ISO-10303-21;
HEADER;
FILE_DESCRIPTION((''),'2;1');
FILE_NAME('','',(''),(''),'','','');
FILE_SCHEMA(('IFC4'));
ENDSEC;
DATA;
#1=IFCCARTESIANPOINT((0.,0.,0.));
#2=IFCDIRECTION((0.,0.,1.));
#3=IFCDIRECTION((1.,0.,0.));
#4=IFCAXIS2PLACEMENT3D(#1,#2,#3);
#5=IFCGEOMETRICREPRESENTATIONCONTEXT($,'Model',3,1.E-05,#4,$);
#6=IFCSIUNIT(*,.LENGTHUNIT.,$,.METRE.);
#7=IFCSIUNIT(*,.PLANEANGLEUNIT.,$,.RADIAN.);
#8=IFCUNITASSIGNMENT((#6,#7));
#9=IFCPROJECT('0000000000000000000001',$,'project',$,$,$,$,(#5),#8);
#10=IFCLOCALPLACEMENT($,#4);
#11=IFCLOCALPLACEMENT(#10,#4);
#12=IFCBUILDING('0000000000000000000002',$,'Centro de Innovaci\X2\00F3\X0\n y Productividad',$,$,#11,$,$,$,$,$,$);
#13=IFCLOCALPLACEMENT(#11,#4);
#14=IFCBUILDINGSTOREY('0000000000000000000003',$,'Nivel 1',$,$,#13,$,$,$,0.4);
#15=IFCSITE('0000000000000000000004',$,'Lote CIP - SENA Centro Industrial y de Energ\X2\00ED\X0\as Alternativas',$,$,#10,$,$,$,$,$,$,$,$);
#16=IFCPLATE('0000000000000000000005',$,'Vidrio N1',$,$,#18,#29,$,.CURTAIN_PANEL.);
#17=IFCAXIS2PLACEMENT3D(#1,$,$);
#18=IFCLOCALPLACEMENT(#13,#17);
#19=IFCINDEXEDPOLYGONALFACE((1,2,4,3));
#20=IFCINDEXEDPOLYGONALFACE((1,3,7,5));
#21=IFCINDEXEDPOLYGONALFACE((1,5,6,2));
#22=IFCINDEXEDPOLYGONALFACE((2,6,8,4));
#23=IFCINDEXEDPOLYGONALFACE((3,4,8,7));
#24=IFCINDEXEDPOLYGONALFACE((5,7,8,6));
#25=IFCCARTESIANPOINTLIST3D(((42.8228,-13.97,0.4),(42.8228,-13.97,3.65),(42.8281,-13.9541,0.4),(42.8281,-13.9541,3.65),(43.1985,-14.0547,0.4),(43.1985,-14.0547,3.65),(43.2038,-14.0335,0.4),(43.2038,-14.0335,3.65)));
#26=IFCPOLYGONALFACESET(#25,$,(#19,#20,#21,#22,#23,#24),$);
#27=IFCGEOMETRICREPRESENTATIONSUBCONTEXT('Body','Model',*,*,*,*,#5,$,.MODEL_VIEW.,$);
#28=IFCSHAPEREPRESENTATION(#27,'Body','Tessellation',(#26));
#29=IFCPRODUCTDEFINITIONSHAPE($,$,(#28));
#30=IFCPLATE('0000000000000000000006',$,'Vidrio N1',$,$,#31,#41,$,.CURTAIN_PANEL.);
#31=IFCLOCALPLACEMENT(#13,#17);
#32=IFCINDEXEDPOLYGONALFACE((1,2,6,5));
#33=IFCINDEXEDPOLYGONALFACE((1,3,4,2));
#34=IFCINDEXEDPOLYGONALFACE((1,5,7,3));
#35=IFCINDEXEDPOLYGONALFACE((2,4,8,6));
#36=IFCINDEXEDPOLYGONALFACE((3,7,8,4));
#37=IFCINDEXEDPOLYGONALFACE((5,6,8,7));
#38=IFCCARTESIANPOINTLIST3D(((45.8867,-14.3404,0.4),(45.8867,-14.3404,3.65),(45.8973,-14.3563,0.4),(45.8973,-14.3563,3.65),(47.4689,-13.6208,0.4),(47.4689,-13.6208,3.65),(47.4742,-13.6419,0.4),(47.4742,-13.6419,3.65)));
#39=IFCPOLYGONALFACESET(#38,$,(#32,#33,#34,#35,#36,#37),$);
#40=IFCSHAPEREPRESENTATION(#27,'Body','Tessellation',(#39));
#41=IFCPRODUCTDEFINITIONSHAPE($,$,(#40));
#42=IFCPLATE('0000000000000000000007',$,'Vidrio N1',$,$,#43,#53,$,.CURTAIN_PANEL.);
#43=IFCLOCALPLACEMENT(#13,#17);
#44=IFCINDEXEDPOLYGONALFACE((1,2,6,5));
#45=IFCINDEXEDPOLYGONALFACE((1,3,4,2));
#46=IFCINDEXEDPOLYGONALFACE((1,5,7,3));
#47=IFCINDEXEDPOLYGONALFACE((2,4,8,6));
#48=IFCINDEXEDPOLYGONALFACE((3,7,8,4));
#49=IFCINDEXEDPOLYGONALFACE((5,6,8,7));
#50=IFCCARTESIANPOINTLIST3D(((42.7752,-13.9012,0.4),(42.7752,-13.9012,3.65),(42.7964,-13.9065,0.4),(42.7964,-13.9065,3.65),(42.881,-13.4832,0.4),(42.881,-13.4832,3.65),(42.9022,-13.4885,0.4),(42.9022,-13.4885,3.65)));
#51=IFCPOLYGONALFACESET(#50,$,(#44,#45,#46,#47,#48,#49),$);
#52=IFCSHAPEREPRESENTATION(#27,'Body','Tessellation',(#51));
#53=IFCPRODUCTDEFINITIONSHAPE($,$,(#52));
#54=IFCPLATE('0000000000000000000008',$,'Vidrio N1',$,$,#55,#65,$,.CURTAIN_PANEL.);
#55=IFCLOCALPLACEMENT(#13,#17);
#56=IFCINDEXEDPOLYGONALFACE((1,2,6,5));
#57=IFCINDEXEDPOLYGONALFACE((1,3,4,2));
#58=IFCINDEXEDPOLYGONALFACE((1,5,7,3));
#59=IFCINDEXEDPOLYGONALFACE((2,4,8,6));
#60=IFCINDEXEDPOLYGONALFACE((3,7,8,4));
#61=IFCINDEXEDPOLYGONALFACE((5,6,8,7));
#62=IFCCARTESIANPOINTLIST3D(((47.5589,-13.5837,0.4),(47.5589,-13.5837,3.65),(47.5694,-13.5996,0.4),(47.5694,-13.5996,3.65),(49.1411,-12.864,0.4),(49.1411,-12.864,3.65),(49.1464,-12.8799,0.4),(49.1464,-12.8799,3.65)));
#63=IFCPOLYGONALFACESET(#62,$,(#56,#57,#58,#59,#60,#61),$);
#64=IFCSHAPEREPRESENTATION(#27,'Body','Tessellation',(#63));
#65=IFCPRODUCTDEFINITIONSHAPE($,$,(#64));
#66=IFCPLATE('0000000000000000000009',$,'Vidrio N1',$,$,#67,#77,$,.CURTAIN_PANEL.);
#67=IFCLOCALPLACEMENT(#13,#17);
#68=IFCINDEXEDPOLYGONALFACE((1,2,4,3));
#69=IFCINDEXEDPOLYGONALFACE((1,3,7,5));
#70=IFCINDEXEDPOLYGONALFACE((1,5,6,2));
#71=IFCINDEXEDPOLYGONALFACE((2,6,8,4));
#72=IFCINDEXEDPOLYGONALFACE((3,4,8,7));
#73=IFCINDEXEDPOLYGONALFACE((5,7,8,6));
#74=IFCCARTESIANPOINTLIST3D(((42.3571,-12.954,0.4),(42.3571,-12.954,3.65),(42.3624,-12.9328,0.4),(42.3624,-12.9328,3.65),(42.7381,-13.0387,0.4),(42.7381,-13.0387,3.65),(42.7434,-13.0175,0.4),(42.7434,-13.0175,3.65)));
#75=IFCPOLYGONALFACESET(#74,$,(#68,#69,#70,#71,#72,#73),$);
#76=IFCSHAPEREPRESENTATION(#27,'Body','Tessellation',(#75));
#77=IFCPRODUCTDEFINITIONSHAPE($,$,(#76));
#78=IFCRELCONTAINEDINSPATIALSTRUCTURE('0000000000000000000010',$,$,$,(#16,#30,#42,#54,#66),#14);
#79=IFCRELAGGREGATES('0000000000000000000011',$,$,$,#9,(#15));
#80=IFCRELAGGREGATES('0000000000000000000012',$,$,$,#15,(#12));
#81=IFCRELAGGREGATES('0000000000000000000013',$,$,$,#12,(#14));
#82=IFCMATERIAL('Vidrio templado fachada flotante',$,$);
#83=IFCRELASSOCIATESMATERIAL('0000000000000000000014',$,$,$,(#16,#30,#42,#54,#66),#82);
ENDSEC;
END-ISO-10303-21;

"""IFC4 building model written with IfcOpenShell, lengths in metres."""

from ifc_helpers import new_model, si_unit, frame, origin_with_axes, place, context, subcontext, project, spatial, polyline, outline, extrude, material, element, save


model = new_model("IFC4")

# Units and contexts
model_context = context("Model", 3, precision=1e-05, world=origin_with_axes())
body_context = subcontext(model_context, "Body", "Model", "MODEL_VIEW")
ifc_project = project(units=[si_unit("LENGTHUNIT", "METRE"), si_unit("PLANEANGLEUNIT", "RADIAN")], contexts=[model_context])

# Site, building, storey
site_placement = place(None, origin_with_axes())
site = spatial("IfcSite", under=ifc_project, at=site_placement, Name="Lote CIP - SENA Centro Industrial y de Energías Alternativas")
building_placement = place(site_placement, origin_with_axes())
building = spatial("IfcBuilding", under=site, at=building_placement, Name="Centro de Innovación y Productividad")
storey_placement = place(building_placement, origin_with_axes())
storey = spatial("IfcBuildingStorey", under=building, at=storey_placement, Name="Nivel 1", Elevation=0.4)

# Plates
ifc_material = material(Name="Vidrio templado fachada flotante")
plate_1_placement = place(storey_placement, origin_with_axes())
element("IfcPlate", 1, at=plate_1_placement, inside=storey, material=ifc_material, Name="Vidrio N1", PredefinedType="CURTAIN_PANEL", context=body_context, shape_type="SweptSolid", body=[
    extrude(outline(polyline([(42.8228, -13.97), (42.8281, -13.9541), (43.2038, -14.0335), (43.1985, -14.0547), (42.8228, -13.97)])), frame((0.0, 0.0, 0.4)), (0.0, 0.0, 1.0), 3.25),
])
plate_2_placement = place(storey_placement, origin_with_axes())
element("IfcPlate", 2, at=plate_2_placement, inside=storey, material=ifc_material, Name="Vidrio N1", PredefinedType="CURTAIN_PANEL", context=body_context, shape_type="SweptSolid", body=[
    extrude(outline(polyline([(47.4742, -13.6419), (45.8973, -14.3563), (45.8867, -14.3404), (47.4689, -13.6208), (47.4742, -13.6419)])), frame((0.0, 0.0, 0.4)), (0.0, 0.0, 1.0), 3.25),
])
plate_3_placement = place(storey_placement, origin_with_axes())
element("IfcPlate", 3, at=plate_3_placement, inside=storey, material=ifc_material, Name="Vidrio N1", PredefinedType="CURTAIN_PANEL", context=body_context, shape_type="SweptSolid", body=[
    extrude(outline(polyline([(42.9022, -13.4885), (42.7964, -13.9065), (42.7752, -13.9012), (42.881, -13.4832), (42.9022, -13.4885)])), frame((0.0, 0.0, 0.4)), (0.0, 0.0, 1.0), 3.25),
])
plate_4_placement = place(storey_placement, origin_with_axes())
element("IfcPlate", 4, at=plate_4_placement, inside=storey, material=ifc_material, Name="Vidrio N1", PredefinedType="CURTAIN_PANEL", context=body_context, shape_type="SweptSolid", body=[
    extrude(outline(polyline([(47.5694, -13.5996), (47.5589, -13.5837), (49.1411, -12.864), (49.1464, -12.8799), (47.5694, -13.5996)])), frame((0.0, 0.0, 0.4)), (0.0, 0.0, 1.0), 3.25),
])
plate_5_placement = place(storey_placement, origin_with_axes())
element("IfcPlate", 5, at=plate_5_placement, inside=storey, material=ifc_material, Name="Vidrio N1", PredefinedType="CURTAIN_PANEL", context=body_context, shape_type="SweptSolid", body=[
    extrude(outline(polyline([(42.7434, -13.0175), (42.7381, -13.0387), (42.3571, -12.954), (42.3624, -12.9328), (42.7434, -13.0175)])), frame((0.0, 0.0, 0.4)), (0.0, 0.0, 1.0), 3.25),
])

save(model, "model.ifc")
